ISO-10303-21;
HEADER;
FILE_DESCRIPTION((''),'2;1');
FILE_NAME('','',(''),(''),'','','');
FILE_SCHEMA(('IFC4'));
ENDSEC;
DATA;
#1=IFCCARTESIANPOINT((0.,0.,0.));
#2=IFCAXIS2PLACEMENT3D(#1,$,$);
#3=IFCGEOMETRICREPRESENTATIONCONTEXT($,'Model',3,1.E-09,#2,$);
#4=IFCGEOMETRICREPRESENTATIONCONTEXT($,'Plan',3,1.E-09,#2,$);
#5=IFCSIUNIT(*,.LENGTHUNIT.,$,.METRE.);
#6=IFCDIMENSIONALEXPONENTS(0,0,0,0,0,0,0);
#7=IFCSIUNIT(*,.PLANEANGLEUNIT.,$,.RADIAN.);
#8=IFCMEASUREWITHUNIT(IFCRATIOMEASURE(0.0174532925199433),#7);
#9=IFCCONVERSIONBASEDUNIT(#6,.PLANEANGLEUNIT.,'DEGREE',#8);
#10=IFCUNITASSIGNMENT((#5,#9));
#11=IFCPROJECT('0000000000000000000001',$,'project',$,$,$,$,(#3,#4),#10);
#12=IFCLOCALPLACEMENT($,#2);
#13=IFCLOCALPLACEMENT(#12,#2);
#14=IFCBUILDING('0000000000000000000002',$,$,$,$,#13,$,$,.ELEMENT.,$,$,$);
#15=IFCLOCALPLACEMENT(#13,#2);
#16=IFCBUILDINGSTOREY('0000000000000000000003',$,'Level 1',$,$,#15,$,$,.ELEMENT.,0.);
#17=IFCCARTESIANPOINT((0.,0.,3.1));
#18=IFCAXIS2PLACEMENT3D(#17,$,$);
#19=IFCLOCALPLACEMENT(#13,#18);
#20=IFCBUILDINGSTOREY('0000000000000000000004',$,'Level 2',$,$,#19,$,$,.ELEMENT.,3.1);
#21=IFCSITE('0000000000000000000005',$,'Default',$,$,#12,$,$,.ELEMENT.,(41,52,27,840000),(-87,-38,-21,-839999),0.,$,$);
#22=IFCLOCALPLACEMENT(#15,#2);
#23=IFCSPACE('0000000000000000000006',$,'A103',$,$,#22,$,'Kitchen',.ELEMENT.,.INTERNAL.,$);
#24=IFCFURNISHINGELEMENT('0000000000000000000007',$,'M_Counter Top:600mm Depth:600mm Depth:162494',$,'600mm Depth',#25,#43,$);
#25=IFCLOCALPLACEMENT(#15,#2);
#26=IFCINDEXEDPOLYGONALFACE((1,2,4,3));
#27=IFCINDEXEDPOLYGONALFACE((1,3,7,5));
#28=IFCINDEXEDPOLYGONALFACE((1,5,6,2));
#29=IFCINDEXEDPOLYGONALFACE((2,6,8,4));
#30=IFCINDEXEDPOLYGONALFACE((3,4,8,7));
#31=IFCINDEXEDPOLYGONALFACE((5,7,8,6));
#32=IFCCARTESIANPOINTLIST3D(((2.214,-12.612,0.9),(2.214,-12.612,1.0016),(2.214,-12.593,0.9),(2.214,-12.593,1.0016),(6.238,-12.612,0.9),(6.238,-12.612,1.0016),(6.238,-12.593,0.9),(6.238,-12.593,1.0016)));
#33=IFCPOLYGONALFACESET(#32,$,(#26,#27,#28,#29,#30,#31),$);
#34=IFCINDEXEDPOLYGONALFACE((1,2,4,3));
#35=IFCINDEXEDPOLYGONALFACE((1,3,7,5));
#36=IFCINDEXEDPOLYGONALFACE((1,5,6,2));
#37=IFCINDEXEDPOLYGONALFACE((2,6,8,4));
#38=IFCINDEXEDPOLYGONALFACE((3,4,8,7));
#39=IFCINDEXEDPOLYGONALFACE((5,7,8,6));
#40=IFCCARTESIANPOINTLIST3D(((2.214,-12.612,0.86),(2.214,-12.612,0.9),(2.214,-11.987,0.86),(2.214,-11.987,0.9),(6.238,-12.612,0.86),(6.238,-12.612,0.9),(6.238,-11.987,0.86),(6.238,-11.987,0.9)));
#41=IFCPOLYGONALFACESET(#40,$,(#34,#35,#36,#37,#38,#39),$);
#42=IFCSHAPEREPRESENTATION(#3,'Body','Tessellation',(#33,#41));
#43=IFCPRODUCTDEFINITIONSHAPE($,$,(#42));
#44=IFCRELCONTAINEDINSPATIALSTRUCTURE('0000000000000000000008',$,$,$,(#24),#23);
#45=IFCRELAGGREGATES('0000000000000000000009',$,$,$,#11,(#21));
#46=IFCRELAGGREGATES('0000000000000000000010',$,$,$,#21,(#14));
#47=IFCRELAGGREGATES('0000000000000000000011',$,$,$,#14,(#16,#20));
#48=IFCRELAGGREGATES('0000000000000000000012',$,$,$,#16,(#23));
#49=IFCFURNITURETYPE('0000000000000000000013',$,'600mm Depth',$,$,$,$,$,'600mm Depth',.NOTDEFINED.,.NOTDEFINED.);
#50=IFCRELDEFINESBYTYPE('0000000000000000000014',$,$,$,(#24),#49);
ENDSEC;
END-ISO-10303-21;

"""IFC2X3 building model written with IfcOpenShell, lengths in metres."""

from ifc_helpers import new_model, entity, si_unit, converted_unit, frame, origin, origin_2d_with_axis, place, context, project, spatial, rectangle, extrude, source, transform, mapped, type_object, type_shapes, element, save


model = new_model("IFC2X3")

# Units and contexts
model_context = context("Model", 3, precision=1e-09, world=origin())
plan_context = context("Plan", 3, precision=1e-09, world=origin())
ifc_project = project(units=[si_unit("LENGTHUNIT", "METRE"), converted_unit("PLANEANGLEUNIT", "DEGREE", entity("IfcRatioMeasure", 0.0174532925199433), si_unit("PLANEANGLEUNIT", "RADIAN"), dimensions=[0, 0, 0, 0, 0, 0, 0])], contexts=[model_context, plan_context])

# Site, building, storey
site_placement = place(None, origin())
site = spatial("IfcSite", under=ifc_project, at=site_placement, Name="Default", CompositionType="ELEMENT", RefLatitude=(41, 52, 27, 840000), RefLongitude=(-87, -38, -21, -839999), RefElevation=0.0)
building_placement = place(site_placement, origin())
building = spatial("IfcBuilding", under=site, at=building_placement, CompositionType="ELEMENT")
storey_1_placement = place(building_placement, origin())
storey_1 = spatial("IfcBuildingStorey", under=building, at=storey_1_placement, Name="Level 1", CompositionType="ELEMENT", Elevation=0.0)

# Shared definitions
storey_2_placement = place(building_placement, frame((0.0, 0.0, 3.1)))
storey_2 = spatial("IfcBuildingStorey", under=building, at=storey_2_placement, Name="Level 2", CompositionType="ELEMENT", Elevation=3.1)

# Shared definitions
space_placement = place(storey_1_placement, origin())
space = spatial("IfcSpace", under=storey_1, at=space_placement, Name="A103", LongName="Kitchen", CompositionType="ELEMENT", InteriorOrExteriorSpace="INTERNAL")

# Furnishing element
furniture_type_1 = type_object("IfcFurnitureType", Name="600mm Depth", ElementType="600mm Depth", AssemblyPlace="NOTDEFINED")
shared_shape_1 = source(origin(), model_context, "Body", "SweptSolid", [
    extrude(rectangle(XDim=0.0191, YDim=4.024, at=origin_2d_with_axis()), frame((0.8115, -0.0095, 0.9), z_axis=(0.0, 0.0, 1.0), x_axis=(0.0, -1.0, 0.0)), (0.0, 0.0, 1.0), 0.1016),
    extrude(rectangle(XDim=4.024, YDim=0.625, at=origin_2d_with_axis()), frame((0.8115, -0.3125, 0.86), z_axis=(0.0, 0.0, 1.0), x_axis=(-1.0, 0.0, 0.0)), (0.0, 0.0, 1.0), 0.04),
])
type_shapes(furniture_type_1, [shared_shape_1])
furnishing_1_placement = place(space_placement, frame((5.0375, -12.612, 0.0), z_axis=(0.0, 0.0, 1.0), x_axis=(-1.0, 0.0, 0.0)))
element("IfcFurnishingElement", 1, at=furnishing_1_placement, inside=space, type_object=furniture_type_1, Name="M_Counter Top:600mm Depth:600mm Depth:162494", ObjectType="600mm Depth", context=model_context, shape_type="MappedRepresentation", body=[
    mapped(shared_shape_1, transform((0.0, 0.0, 0.0), scale=1.0)),
])

save(model, "model.ifc")
